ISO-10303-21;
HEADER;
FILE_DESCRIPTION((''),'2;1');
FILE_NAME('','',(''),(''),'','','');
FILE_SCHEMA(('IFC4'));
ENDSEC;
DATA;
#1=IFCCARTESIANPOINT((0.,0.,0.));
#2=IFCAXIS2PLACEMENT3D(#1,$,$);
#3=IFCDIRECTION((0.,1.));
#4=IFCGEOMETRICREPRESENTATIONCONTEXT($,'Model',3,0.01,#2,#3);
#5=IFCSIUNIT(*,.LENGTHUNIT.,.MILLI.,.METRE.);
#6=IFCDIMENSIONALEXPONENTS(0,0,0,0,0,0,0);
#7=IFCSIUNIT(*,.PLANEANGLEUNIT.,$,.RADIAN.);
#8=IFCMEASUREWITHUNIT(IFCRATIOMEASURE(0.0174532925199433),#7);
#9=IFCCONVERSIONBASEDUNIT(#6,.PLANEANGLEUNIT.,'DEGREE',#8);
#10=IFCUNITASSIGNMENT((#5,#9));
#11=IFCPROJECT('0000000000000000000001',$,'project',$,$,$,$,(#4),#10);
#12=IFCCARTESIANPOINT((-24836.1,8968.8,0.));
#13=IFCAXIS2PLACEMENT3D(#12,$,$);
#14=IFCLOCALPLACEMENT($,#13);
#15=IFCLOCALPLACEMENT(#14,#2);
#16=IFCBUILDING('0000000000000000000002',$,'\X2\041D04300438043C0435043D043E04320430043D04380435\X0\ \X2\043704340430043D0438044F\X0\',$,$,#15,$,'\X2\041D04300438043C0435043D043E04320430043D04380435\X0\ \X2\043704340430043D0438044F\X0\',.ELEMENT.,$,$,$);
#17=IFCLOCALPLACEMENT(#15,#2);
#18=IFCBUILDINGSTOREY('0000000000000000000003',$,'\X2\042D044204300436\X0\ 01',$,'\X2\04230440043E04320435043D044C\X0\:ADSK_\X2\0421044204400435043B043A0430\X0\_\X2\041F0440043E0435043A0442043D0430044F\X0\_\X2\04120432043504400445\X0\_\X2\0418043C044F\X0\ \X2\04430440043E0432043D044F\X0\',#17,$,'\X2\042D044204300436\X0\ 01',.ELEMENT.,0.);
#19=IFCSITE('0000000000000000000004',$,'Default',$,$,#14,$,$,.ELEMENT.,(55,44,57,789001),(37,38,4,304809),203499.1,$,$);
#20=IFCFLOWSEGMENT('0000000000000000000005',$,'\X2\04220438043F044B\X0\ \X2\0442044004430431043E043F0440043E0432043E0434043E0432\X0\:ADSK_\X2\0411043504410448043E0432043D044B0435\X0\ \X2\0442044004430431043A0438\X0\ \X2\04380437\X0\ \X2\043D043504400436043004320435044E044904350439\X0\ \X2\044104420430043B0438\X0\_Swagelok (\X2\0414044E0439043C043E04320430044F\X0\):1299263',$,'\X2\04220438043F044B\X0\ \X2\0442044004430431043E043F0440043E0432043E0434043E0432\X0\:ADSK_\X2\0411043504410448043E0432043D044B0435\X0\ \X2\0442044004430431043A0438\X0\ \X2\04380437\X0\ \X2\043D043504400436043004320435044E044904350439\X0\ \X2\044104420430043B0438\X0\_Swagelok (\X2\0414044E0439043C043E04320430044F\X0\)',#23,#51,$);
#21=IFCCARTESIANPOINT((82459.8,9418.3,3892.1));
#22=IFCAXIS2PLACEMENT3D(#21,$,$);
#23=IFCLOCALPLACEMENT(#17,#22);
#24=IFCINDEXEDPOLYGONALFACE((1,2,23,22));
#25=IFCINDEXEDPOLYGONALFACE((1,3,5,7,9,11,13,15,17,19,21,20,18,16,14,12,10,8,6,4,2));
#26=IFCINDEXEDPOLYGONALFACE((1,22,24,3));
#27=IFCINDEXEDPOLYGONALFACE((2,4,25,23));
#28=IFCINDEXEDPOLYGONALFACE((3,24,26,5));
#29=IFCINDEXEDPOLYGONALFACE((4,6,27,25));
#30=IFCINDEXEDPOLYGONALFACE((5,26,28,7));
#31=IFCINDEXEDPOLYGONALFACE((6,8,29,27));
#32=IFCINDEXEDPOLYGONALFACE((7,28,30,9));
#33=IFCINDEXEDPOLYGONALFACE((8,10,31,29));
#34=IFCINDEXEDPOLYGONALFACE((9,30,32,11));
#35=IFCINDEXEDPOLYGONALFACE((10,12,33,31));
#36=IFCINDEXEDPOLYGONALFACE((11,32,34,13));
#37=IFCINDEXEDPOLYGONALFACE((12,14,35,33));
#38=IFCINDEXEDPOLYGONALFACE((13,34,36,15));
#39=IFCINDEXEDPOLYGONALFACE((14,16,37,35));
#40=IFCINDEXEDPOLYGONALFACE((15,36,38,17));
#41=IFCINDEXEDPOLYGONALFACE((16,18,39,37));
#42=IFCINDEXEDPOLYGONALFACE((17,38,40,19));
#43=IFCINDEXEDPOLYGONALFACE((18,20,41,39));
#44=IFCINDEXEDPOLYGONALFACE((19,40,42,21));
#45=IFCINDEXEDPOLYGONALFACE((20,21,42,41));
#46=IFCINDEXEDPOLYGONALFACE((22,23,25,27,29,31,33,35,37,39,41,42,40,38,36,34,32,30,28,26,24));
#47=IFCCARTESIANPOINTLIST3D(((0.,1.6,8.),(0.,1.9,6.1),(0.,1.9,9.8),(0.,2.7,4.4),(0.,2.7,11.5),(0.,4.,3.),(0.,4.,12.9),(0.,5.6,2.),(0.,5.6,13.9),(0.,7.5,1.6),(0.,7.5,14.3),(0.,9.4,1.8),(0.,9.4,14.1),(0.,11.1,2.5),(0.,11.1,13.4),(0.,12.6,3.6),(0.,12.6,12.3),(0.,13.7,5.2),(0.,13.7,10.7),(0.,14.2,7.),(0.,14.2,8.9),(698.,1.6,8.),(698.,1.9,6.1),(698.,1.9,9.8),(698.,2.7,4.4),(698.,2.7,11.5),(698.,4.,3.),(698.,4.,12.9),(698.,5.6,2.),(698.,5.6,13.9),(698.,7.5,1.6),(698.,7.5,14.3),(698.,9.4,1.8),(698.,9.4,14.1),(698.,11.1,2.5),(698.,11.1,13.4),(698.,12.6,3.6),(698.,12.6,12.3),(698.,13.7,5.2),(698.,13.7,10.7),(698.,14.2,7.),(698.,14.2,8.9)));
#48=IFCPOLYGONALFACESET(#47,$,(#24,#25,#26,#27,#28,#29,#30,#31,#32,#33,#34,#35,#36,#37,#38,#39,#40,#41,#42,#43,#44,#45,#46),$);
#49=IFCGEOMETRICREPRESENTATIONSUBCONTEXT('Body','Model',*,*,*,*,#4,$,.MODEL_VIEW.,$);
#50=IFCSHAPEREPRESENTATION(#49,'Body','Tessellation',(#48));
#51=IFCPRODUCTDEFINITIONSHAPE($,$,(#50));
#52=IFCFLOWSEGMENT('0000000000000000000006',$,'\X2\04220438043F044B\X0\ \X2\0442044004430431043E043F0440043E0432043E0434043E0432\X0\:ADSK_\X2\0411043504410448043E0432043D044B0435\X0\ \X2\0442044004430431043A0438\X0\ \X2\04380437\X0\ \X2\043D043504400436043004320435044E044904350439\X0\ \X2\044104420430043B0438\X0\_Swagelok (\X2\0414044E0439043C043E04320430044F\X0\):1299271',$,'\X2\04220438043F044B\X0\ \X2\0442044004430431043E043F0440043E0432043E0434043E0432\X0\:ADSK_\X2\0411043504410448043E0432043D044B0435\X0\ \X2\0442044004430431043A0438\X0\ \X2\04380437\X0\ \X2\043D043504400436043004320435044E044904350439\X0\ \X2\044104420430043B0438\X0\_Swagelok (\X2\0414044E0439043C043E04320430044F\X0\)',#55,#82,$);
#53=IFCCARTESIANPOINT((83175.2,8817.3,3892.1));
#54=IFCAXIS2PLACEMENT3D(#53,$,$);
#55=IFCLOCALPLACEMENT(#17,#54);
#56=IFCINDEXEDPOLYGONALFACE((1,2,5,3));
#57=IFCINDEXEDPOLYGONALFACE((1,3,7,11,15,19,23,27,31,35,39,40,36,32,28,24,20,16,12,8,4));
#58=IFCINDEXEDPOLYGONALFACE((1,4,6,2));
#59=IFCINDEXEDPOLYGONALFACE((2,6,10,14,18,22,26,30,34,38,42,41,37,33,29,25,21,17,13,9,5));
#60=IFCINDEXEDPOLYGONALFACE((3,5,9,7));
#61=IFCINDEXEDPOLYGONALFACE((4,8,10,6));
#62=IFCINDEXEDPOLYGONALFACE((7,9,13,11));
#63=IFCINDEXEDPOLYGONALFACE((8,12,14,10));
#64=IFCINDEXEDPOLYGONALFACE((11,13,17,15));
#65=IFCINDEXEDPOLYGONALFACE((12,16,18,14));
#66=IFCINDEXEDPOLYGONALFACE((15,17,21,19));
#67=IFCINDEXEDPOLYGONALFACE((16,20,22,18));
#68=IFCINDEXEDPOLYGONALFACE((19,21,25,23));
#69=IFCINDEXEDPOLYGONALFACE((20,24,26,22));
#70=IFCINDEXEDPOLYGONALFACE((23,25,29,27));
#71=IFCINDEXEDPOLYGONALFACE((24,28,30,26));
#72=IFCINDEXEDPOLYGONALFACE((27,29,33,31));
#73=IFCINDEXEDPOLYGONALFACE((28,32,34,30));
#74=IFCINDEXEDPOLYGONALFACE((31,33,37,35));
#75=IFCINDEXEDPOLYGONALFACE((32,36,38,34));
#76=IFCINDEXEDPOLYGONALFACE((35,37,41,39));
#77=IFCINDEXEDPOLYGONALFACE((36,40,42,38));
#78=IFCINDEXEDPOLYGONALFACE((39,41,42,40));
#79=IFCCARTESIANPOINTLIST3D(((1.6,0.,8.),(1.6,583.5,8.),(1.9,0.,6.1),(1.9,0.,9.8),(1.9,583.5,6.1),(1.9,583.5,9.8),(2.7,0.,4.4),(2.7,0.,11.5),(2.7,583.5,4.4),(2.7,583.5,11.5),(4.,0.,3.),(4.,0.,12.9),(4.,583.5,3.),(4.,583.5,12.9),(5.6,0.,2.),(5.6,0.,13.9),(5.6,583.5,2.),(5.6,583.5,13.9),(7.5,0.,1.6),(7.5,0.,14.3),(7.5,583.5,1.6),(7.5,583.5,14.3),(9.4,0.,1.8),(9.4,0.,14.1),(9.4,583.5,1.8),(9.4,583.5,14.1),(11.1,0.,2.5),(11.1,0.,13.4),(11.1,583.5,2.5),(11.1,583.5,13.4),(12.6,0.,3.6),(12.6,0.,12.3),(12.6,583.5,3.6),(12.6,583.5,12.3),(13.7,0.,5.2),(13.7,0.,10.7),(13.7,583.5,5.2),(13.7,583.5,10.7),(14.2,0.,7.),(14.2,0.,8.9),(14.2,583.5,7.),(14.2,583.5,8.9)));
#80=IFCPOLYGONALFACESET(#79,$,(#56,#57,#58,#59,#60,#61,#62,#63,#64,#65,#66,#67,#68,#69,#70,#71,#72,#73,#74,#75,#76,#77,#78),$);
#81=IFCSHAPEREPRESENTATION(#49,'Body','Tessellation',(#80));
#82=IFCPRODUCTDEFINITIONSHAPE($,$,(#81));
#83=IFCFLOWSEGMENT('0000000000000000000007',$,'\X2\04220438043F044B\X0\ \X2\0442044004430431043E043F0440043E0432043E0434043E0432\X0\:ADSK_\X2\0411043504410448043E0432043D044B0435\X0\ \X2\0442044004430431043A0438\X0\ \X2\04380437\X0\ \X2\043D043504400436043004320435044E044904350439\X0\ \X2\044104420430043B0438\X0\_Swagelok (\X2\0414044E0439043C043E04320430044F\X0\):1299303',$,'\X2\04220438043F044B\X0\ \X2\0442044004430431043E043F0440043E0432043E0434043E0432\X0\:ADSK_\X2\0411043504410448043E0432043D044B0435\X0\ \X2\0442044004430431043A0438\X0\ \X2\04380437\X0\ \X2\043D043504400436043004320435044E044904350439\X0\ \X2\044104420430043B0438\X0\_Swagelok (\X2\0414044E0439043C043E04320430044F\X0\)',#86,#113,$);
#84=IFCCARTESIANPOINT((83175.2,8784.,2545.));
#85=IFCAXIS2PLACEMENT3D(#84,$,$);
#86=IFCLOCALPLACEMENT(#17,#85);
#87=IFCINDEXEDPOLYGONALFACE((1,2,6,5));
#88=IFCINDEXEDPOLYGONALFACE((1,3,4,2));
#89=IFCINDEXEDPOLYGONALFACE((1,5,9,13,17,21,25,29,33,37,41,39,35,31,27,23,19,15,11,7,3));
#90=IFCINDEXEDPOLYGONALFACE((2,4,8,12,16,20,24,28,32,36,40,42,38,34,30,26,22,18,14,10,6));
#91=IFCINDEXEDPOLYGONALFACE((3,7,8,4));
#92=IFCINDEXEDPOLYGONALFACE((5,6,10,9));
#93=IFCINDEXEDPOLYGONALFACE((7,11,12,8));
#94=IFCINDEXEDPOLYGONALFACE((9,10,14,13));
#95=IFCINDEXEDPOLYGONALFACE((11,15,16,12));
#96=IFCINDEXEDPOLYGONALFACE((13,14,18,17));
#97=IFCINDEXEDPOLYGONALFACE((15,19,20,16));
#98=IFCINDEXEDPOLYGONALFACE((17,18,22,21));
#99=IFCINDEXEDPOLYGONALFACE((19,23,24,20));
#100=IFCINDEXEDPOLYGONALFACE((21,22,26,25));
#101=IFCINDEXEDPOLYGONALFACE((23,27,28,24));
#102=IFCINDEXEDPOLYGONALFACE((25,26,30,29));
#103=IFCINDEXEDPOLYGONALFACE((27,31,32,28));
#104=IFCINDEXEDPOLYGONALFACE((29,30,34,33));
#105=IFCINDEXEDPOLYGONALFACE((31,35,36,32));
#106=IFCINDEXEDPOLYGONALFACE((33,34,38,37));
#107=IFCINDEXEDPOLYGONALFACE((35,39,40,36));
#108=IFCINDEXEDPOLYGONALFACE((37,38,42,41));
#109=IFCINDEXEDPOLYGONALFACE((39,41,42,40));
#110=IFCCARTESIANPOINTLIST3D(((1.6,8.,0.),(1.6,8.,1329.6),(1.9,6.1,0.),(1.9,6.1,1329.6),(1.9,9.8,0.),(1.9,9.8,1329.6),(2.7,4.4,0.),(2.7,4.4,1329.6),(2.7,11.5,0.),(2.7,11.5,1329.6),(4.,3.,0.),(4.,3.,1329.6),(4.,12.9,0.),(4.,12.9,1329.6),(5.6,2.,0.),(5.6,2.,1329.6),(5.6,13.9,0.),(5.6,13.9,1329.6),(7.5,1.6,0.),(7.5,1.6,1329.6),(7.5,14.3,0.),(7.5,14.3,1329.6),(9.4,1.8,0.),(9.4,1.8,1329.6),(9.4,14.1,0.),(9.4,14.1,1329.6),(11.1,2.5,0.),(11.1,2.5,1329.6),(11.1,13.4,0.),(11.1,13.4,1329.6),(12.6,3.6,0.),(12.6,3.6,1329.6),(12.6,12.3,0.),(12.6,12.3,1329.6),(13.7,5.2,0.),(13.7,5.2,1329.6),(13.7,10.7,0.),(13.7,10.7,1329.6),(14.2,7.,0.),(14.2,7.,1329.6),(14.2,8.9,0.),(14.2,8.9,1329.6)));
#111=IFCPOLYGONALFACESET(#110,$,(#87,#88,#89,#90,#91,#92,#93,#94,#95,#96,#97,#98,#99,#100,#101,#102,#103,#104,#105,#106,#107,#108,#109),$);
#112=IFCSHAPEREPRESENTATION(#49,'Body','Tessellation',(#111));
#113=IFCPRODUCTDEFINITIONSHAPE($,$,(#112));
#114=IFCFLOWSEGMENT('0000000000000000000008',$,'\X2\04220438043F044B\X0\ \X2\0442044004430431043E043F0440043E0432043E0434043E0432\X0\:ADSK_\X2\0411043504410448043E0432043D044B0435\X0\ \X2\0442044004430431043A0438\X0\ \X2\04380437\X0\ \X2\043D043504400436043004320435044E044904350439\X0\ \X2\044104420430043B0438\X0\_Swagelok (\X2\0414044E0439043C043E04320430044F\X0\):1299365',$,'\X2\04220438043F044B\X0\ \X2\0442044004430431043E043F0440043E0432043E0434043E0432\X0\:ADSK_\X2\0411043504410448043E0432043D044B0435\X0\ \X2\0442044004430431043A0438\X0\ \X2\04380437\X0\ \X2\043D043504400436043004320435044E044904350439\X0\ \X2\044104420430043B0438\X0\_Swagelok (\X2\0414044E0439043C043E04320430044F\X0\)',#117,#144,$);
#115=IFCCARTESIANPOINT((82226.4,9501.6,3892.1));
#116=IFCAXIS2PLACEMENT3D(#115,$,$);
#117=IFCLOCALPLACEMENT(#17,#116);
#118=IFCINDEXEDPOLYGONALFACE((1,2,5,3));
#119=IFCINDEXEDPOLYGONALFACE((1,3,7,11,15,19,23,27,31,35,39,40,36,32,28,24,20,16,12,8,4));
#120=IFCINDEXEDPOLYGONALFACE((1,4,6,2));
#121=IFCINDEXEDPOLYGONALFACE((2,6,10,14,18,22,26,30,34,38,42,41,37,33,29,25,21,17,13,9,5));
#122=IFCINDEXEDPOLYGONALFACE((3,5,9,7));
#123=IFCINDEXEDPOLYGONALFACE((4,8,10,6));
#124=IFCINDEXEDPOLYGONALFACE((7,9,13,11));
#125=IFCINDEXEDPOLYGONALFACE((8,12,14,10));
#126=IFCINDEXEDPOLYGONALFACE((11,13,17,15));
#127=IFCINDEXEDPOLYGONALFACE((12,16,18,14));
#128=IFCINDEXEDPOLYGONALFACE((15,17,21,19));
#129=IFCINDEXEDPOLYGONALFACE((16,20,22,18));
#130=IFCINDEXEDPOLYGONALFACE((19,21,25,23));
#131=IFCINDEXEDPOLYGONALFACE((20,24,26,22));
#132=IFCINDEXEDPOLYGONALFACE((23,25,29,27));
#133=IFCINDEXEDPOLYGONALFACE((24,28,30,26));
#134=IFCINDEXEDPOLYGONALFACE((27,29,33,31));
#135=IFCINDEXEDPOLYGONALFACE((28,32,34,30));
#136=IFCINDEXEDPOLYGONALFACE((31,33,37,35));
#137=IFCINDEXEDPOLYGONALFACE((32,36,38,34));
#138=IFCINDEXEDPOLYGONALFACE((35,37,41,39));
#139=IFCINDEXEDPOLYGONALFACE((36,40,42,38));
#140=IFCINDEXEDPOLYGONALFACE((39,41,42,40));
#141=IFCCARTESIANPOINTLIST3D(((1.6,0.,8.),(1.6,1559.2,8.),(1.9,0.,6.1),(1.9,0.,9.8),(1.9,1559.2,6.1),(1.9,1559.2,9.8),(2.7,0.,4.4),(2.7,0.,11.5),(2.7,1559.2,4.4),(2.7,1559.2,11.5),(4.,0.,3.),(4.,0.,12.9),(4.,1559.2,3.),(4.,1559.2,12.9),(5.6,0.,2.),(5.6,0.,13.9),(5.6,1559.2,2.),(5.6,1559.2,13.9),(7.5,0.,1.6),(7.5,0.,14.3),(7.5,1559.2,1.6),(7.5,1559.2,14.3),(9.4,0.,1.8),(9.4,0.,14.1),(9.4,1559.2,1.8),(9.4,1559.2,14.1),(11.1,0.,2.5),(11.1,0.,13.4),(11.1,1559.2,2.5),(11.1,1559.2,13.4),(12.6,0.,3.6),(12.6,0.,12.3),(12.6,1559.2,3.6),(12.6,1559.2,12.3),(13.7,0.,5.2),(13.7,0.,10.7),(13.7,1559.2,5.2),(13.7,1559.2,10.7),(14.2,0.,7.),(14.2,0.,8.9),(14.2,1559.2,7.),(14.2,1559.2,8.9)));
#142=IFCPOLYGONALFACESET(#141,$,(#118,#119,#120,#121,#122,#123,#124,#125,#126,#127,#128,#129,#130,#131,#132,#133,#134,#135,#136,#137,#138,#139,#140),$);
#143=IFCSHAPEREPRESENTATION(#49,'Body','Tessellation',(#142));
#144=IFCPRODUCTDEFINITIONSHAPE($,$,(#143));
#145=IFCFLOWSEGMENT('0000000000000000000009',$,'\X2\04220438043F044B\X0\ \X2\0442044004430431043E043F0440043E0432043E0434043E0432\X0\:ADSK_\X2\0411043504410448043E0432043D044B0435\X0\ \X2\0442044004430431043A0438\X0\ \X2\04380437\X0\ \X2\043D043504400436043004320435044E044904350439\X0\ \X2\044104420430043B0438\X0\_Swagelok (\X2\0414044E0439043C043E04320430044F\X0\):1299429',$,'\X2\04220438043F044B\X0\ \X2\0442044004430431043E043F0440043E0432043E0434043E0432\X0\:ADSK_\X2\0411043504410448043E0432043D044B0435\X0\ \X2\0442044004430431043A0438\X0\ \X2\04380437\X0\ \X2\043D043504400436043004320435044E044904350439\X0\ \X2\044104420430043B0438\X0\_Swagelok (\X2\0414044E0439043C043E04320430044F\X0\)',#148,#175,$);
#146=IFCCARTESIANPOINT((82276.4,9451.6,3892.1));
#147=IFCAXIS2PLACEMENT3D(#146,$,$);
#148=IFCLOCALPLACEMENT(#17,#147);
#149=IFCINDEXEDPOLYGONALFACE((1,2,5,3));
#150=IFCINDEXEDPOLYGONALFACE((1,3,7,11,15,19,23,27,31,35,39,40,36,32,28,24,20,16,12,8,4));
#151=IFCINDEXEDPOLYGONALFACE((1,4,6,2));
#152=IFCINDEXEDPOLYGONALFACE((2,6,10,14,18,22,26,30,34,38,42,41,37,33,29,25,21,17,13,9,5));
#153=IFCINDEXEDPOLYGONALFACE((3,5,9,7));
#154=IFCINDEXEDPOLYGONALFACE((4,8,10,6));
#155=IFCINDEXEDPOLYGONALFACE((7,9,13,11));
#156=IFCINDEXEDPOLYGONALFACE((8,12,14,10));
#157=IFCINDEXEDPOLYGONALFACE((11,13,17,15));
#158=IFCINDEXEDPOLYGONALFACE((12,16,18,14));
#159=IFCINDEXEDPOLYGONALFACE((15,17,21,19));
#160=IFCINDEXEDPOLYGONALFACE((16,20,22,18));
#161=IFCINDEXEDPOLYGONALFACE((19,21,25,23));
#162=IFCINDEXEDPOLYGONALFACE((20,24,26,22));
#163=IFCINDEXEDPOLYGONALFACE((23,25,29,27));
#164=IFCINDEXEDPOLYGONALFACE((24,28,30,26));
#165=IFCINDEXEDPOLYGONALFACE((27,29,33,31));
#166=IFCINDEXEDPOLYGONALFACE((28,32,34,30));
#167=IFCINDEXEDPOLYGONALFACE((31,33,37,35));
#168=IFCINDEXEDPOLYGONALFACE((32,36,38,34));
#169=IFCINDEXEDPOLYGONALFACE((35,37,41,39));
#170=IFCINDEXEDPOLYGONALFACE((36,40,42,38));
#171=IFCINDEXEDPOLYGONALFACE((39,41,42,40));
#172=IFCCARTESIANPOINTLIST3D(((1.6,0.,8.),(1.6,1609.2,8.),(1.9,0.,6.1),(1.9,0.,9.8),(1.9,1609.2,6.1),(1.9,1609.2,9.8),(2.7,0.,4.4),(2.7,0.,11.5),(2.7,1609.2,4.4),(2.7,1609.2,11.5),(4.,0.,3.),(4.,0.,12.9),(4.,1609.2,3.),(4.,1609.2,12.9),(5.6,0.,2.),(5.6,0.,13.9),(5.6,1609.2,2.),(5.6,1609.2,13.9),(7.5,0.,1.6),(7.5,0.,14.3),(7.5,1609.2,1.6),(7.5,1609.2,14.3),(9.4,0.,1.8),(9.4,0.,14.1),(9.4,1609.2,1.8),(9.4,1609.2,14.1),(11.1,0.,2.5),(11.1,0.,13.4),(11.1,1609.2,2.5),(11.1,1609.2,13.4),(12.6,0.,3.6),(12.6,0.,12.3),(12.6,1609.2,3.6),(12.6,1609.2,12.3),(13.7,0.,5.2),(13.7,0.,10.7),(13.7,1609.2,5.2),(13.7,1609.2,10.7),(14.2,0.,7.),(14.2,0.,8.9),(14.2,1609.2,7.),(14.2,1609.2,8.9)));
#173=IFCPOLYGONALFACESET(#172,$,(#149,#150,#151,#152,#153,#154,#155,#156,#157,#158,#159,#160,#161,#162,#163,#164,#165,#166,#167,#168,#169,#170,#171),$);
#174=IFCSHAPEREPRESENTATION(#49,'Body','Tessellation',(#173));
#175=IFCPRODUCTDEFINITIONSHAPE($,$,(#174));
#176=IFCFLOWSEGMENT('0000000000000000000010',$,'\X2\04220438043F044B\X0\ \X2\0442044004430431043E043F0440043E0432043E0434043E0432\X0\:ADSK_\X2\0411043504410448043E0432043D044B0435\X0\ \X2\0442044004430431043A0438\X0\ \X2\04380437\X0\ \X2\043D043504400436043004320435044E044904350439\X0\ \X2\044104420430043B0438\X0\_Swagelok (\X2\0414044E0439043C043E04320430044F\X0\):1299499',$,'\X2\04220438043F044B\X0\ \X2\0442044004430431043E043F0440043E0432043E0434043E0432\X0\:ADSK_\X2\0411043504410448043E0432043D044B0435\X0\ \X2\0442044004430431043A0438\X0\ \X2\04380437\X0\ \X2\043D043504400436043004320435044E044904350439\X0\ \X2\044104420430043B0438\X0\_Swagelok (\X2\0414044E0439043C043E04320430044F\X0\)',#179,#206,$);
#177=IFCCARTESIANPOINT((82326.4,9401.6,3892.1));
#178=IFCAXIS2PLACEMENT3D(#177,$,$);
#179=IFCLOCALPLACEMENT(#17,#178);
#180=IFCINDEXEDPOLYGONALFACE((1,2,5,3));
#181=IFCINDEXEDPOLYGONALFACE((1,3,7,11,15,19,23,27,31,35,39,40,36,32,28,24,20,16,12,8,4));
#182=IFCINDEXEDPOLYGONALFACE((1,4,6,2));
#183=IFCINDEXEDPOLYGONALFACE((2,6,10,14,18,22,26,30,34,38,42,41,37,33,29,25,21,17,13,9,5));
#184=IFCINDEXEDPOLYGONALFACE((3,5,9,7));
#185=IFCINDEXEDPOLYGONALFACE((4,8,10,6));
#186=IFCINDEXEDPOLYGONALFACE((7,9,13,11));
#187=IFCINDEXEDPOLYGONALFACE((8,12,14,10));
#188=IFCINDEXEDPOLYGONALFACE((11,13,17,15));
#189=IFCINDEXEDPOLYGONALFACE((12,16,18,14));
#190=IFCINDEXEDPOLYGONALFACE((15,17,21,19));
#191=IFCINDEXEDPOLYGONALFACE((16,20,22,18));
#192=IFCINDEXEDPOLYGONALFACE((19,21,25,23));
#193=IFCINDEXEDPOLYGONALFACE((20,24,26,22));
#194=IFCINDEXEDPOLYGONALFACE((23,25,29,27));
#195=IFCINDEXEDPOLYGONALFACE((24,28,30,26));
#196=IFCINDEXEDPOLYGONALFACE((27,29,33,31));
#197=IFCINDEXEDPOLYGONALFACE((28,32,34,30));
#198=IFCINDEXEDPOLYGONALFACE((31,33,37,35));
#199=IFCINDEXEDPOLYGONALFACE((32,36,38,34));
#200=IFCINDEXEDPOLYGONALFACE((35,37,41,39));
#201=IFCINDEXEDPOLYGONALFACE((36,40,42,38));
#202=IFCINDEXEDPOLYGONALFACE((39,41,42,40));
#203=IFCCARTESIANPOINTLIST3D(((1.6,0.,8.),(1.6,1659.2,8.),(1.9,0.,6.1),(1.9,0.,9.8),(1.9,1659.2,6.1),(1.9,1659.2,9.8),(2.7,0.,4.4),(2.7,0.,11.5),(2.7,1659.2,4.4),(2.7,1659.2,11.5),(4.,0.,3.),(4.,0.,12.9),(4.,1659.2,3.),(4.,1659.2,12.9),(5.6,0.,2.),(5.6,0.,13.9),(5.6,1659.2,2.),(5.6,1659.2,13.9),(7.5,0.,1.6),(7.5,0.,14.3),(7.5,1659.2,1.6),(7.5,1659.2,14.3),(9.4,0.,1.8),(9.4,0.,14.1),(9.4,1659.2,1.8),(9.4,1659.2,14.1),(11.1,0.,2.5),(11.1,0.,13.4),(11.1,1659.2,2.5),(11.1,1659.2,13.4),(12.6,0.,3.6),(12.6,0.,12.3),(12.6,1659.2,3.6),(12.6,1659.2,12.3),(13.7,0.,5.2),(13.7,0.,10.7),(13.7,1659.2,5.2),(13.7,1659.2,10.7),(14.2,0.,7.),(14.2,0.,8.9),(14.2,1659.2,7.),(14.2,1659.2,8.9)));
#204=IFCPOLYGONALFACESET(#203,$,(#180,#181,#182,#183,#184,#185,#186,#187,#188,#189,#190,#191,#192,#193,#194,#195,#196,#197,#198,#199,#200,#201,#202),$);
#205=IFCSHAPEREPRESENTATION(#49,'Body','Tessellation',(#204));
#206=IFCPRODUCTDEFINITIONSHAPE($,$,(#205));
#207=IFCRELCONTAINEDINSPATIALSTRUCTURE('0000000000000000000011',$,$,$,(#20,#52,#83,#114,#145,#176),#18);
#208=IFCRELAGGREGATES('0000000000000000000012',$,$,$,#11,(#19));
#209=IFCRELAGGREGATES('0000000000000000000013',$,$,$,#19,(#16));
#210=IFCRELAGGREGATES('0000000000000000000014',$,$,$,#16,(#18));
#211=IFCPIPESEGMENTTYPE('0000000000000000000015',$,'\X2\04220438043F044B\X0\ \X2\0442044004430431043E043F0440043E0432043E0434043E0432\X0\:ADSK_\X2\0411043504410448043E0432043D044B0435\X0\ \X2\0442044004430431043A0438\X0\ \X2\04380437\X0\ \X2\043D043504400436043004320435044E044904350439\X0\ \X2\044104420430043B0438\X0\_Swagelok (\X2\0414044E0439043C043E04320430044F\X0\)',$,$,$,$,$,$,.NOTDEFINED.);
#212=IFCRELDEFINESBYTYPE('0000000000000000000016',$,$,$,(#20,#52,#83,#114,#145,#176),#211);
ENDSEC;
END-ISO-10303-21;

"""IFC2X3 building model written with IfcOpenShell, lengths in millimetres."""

from ifc_helpers import new_model, entity, si_unit, converted_unit, direction, frame, origin, origin_2d_with_axis, place, context, subcontext, project, spatial, circle, extrude, type_object, element, save


model = new_model("IFC2X3")

# Units and contexts
model_context = context("Model", 3, precision=0.01, world=origin(), true_north=direction((0.0, 1.0)))
body_context = subcontext(model_context, "Body", "Model", "MODEL_VIEW")
ifc_project = project(units=[si_unit("LENGTHUNIT", "METRE", prefix="MILLI"), converted_unit("PLANEANGLEUNIT", "DEGREE", entity("IfcRatioMeasure", 0.0174532925199433), si_unit("PLANEANGLEUNIT", "RADIAN"), dimensions=[0, 0, 0, 0, 0, 0, 0])], contexts=[model_context])

# Site, building, storey
site_placement = place(None, frame((-24836.1, 8968.8, 0.0)))
site = spatial("IfcSite", under=ifc_project, at=site_placement, Name="Default", CompositionType="ELEMENT", RefLatitude=(55, 44, 57, 789001), RefLongitude=(37, 38, 4, 304809), RefElevation=203499.1)
building_placement = place(site_placement, origin())
building = spatial("IfcBuilding", under=site, at=building_placement, Name="Наименование здания", LongName="Наименование здания", CompositionType="ELEMENT")
storey_placement = place(building_placement, origin())
storey = spatial("IfcBuildingStorey", under=building, at=storey_placement, Name="Этаж 01", ObjectType="Уровень:ADSK_Стрелка_Проектная_Вверх_Имя уровня", LongName="Этаж 01", CompositionType="ELEMENT", Elevation=0.0)

# Flow segments
pipe_segment_type = type_object("IfcPipeSegmentType", Name="Типы трубопроводов:ADSK_Бесшовные трубки из нержавеющей стали_Swagelok (Дюймовая)", PredefinedType="NOTDEFINED")
flow_segment_1_placement = place(storey_placement, frame((82459.8, 9418.3, 3892.1)))
element("IfcFlowSegment", 1, at=flow_segment_1_placement, inside=storey, type_object=pipe_segment_type, Name="Типы трубопроводов:ADSK_Бесшовные трубки из нержавеющей стали_Swagelok (Дюймовая):1299263", ObjectType="Типы трубопроводов:ADSK_Бесшовные трубки из нержавеющей стали_Swagelok (Дюймовая)", context=body_context, shape_type="SweptSolid", body=[
    extrude(circle(Radius=6.3, at=origin_2d_with_axis()), frame((0.0, 8.0, 8.0), z_axis=(1.0, 0.0, 0.0), x_axis=(0.0, -1.0, 0.0)), (0.0, 0.0, 1.0), 698.0),
])
flow_segment_2_placement = place(storey_placement, frame((83175.2, 8817.3, 3892.1)))
element("IfcFlowSegment", 2, at=flow_segment_2_placement, inside=storey, type_object=pipe_segment_type, Name="Типы трубопроводов:ADSK_Бесшовные трубки из нержавеющей стали_Swagelok (Дюймовая):1299271", ObjectType="Типы трубопроводов:ADSK_Бесшовные трубки из нержавеющей стали_Swagelok (Дюймовая)", context=body_context, shape_type="SweptSolid", body=[
    extrude(circle(Radius=6.3, at=origin_2d_with_axis()), frame((8.0, 0.0, 8.0), z_axis=(0.0, 1.0, 0.0), x_axis=(-1.0, 0.0, 0.0)), (0.0, 0.0, 1.0), 583.5),
])
flow_segment_3_placement = place(storey_placement, frame((83175.2, 8784.0, 2545.0)))
element("IfcFlowSegment", 3, at=flow_segment_3_placement, inside=storey, type_object=pipe_segment_type, Name="Типы трубопроводов:ADSK_Бесшовные трубки из нержавеющей стали_Swagelok (Дюймовая):1299303", ObjectType="Типы трубопроводов:ADSK_Бесшовные трубки из нержавеющей стали_Swagelok (Дюймовая)", context=body_context, shape_type="SweptSolid", body=[
    extrude(circle(Radius=6.3, at=origin_2d_with_axis()), frame((8.0, 8.0, 0.0), z_axis=(0.0, 0.0, 1.0), x_axis=(-1.0, 0.0, 0.0)), (0.0, 0.0, 1.0), 1329.6),
])
flow_segment_4_placement = place(storey_placement, frame((82226.4, 9501.6, 3892.1)))
element("IfcFlowSegment", 4, at=flow_segment_4_placement, inside=storey, type_object=pipe_segment_type, Name="Типы трубопроводов:ADSK_Бесшовные трубки из нержавеющей стали_Swagelok (Дюймовая):1299365", ObjectType="Типы трубопроводов:ADSK_Бесшовные трубки из нержавеющей стали_Swagelok (Дюймовая)", context=body_context, shape_type="SweptSolid", body=[
    extrude(circle(Radius=6.3, at=origin_2d_with_axis()), frame((8.0, 0.0, 8.0), z_axis=(0.0, 1.0, 0.0), x_axis=(-1.0, 0.0, 0.0)), (0.0, 0.0, 1.0), 1559.2),
])
flow_segment_5_placement = place(storey_placement, frame((82276.4, 9451.6, 3892.1)))
element("IfcFlowSegment", 5, at=flow_segment_5_placement, inside=storey, type_object=pipe_segment_type, Name="Типы трубопроводов:ADSK_Бесшовные трубки из нержавеющей стали_Swagelok (Дюймовая):1299429", ObjectType="Типы трубопроводов:ADSK_Бесшовные трубки из нержавеющей стали_Swagelok (Дюймовая)", context=body_context, shape_type="SweptSolid", body=[
    extrude(circle(Radius=6.3, at=origin_2d_with_axis()), frame((8.0, 0.0, 8.0), z_axis=(0.0, 1.0, 0.0), x_axis=(-1.0, 0.0, 0.0)), (0.0, 0.0, 1.0), 1609.2),
])
flow_segment_6_placement = place(storey_placement, frame((82326.4, 9401.6, 3892.1)))
element("IfcFlowSegment", 6, at=flow_segment_6_placement, inside=storey, type_object=pipe_segment_type, Name="Типы трубопроводов:ADSK_Бесшовные трубки из нержавеющей стали_Swagelok (Дюймовая):1299499", ObjectType="Типы трубопроводов:ADSK_Бесшовные трубки из нержавеющей стали_Swagelok (Дюймовая)", context=body_context, shape_type="SweptSolid", body=[
    extrude(circle(Radius=6.3, at=origin_2d_with_axis()), frame((8.0, 0.0, 8.0), z_axis=(0.0, 1.0, 0.0), x_axis=(-1.0, 0.0, 0.0)), (0.0, 0.0, 1.0), 1659.2),
])

save(model, "model.ifc")
